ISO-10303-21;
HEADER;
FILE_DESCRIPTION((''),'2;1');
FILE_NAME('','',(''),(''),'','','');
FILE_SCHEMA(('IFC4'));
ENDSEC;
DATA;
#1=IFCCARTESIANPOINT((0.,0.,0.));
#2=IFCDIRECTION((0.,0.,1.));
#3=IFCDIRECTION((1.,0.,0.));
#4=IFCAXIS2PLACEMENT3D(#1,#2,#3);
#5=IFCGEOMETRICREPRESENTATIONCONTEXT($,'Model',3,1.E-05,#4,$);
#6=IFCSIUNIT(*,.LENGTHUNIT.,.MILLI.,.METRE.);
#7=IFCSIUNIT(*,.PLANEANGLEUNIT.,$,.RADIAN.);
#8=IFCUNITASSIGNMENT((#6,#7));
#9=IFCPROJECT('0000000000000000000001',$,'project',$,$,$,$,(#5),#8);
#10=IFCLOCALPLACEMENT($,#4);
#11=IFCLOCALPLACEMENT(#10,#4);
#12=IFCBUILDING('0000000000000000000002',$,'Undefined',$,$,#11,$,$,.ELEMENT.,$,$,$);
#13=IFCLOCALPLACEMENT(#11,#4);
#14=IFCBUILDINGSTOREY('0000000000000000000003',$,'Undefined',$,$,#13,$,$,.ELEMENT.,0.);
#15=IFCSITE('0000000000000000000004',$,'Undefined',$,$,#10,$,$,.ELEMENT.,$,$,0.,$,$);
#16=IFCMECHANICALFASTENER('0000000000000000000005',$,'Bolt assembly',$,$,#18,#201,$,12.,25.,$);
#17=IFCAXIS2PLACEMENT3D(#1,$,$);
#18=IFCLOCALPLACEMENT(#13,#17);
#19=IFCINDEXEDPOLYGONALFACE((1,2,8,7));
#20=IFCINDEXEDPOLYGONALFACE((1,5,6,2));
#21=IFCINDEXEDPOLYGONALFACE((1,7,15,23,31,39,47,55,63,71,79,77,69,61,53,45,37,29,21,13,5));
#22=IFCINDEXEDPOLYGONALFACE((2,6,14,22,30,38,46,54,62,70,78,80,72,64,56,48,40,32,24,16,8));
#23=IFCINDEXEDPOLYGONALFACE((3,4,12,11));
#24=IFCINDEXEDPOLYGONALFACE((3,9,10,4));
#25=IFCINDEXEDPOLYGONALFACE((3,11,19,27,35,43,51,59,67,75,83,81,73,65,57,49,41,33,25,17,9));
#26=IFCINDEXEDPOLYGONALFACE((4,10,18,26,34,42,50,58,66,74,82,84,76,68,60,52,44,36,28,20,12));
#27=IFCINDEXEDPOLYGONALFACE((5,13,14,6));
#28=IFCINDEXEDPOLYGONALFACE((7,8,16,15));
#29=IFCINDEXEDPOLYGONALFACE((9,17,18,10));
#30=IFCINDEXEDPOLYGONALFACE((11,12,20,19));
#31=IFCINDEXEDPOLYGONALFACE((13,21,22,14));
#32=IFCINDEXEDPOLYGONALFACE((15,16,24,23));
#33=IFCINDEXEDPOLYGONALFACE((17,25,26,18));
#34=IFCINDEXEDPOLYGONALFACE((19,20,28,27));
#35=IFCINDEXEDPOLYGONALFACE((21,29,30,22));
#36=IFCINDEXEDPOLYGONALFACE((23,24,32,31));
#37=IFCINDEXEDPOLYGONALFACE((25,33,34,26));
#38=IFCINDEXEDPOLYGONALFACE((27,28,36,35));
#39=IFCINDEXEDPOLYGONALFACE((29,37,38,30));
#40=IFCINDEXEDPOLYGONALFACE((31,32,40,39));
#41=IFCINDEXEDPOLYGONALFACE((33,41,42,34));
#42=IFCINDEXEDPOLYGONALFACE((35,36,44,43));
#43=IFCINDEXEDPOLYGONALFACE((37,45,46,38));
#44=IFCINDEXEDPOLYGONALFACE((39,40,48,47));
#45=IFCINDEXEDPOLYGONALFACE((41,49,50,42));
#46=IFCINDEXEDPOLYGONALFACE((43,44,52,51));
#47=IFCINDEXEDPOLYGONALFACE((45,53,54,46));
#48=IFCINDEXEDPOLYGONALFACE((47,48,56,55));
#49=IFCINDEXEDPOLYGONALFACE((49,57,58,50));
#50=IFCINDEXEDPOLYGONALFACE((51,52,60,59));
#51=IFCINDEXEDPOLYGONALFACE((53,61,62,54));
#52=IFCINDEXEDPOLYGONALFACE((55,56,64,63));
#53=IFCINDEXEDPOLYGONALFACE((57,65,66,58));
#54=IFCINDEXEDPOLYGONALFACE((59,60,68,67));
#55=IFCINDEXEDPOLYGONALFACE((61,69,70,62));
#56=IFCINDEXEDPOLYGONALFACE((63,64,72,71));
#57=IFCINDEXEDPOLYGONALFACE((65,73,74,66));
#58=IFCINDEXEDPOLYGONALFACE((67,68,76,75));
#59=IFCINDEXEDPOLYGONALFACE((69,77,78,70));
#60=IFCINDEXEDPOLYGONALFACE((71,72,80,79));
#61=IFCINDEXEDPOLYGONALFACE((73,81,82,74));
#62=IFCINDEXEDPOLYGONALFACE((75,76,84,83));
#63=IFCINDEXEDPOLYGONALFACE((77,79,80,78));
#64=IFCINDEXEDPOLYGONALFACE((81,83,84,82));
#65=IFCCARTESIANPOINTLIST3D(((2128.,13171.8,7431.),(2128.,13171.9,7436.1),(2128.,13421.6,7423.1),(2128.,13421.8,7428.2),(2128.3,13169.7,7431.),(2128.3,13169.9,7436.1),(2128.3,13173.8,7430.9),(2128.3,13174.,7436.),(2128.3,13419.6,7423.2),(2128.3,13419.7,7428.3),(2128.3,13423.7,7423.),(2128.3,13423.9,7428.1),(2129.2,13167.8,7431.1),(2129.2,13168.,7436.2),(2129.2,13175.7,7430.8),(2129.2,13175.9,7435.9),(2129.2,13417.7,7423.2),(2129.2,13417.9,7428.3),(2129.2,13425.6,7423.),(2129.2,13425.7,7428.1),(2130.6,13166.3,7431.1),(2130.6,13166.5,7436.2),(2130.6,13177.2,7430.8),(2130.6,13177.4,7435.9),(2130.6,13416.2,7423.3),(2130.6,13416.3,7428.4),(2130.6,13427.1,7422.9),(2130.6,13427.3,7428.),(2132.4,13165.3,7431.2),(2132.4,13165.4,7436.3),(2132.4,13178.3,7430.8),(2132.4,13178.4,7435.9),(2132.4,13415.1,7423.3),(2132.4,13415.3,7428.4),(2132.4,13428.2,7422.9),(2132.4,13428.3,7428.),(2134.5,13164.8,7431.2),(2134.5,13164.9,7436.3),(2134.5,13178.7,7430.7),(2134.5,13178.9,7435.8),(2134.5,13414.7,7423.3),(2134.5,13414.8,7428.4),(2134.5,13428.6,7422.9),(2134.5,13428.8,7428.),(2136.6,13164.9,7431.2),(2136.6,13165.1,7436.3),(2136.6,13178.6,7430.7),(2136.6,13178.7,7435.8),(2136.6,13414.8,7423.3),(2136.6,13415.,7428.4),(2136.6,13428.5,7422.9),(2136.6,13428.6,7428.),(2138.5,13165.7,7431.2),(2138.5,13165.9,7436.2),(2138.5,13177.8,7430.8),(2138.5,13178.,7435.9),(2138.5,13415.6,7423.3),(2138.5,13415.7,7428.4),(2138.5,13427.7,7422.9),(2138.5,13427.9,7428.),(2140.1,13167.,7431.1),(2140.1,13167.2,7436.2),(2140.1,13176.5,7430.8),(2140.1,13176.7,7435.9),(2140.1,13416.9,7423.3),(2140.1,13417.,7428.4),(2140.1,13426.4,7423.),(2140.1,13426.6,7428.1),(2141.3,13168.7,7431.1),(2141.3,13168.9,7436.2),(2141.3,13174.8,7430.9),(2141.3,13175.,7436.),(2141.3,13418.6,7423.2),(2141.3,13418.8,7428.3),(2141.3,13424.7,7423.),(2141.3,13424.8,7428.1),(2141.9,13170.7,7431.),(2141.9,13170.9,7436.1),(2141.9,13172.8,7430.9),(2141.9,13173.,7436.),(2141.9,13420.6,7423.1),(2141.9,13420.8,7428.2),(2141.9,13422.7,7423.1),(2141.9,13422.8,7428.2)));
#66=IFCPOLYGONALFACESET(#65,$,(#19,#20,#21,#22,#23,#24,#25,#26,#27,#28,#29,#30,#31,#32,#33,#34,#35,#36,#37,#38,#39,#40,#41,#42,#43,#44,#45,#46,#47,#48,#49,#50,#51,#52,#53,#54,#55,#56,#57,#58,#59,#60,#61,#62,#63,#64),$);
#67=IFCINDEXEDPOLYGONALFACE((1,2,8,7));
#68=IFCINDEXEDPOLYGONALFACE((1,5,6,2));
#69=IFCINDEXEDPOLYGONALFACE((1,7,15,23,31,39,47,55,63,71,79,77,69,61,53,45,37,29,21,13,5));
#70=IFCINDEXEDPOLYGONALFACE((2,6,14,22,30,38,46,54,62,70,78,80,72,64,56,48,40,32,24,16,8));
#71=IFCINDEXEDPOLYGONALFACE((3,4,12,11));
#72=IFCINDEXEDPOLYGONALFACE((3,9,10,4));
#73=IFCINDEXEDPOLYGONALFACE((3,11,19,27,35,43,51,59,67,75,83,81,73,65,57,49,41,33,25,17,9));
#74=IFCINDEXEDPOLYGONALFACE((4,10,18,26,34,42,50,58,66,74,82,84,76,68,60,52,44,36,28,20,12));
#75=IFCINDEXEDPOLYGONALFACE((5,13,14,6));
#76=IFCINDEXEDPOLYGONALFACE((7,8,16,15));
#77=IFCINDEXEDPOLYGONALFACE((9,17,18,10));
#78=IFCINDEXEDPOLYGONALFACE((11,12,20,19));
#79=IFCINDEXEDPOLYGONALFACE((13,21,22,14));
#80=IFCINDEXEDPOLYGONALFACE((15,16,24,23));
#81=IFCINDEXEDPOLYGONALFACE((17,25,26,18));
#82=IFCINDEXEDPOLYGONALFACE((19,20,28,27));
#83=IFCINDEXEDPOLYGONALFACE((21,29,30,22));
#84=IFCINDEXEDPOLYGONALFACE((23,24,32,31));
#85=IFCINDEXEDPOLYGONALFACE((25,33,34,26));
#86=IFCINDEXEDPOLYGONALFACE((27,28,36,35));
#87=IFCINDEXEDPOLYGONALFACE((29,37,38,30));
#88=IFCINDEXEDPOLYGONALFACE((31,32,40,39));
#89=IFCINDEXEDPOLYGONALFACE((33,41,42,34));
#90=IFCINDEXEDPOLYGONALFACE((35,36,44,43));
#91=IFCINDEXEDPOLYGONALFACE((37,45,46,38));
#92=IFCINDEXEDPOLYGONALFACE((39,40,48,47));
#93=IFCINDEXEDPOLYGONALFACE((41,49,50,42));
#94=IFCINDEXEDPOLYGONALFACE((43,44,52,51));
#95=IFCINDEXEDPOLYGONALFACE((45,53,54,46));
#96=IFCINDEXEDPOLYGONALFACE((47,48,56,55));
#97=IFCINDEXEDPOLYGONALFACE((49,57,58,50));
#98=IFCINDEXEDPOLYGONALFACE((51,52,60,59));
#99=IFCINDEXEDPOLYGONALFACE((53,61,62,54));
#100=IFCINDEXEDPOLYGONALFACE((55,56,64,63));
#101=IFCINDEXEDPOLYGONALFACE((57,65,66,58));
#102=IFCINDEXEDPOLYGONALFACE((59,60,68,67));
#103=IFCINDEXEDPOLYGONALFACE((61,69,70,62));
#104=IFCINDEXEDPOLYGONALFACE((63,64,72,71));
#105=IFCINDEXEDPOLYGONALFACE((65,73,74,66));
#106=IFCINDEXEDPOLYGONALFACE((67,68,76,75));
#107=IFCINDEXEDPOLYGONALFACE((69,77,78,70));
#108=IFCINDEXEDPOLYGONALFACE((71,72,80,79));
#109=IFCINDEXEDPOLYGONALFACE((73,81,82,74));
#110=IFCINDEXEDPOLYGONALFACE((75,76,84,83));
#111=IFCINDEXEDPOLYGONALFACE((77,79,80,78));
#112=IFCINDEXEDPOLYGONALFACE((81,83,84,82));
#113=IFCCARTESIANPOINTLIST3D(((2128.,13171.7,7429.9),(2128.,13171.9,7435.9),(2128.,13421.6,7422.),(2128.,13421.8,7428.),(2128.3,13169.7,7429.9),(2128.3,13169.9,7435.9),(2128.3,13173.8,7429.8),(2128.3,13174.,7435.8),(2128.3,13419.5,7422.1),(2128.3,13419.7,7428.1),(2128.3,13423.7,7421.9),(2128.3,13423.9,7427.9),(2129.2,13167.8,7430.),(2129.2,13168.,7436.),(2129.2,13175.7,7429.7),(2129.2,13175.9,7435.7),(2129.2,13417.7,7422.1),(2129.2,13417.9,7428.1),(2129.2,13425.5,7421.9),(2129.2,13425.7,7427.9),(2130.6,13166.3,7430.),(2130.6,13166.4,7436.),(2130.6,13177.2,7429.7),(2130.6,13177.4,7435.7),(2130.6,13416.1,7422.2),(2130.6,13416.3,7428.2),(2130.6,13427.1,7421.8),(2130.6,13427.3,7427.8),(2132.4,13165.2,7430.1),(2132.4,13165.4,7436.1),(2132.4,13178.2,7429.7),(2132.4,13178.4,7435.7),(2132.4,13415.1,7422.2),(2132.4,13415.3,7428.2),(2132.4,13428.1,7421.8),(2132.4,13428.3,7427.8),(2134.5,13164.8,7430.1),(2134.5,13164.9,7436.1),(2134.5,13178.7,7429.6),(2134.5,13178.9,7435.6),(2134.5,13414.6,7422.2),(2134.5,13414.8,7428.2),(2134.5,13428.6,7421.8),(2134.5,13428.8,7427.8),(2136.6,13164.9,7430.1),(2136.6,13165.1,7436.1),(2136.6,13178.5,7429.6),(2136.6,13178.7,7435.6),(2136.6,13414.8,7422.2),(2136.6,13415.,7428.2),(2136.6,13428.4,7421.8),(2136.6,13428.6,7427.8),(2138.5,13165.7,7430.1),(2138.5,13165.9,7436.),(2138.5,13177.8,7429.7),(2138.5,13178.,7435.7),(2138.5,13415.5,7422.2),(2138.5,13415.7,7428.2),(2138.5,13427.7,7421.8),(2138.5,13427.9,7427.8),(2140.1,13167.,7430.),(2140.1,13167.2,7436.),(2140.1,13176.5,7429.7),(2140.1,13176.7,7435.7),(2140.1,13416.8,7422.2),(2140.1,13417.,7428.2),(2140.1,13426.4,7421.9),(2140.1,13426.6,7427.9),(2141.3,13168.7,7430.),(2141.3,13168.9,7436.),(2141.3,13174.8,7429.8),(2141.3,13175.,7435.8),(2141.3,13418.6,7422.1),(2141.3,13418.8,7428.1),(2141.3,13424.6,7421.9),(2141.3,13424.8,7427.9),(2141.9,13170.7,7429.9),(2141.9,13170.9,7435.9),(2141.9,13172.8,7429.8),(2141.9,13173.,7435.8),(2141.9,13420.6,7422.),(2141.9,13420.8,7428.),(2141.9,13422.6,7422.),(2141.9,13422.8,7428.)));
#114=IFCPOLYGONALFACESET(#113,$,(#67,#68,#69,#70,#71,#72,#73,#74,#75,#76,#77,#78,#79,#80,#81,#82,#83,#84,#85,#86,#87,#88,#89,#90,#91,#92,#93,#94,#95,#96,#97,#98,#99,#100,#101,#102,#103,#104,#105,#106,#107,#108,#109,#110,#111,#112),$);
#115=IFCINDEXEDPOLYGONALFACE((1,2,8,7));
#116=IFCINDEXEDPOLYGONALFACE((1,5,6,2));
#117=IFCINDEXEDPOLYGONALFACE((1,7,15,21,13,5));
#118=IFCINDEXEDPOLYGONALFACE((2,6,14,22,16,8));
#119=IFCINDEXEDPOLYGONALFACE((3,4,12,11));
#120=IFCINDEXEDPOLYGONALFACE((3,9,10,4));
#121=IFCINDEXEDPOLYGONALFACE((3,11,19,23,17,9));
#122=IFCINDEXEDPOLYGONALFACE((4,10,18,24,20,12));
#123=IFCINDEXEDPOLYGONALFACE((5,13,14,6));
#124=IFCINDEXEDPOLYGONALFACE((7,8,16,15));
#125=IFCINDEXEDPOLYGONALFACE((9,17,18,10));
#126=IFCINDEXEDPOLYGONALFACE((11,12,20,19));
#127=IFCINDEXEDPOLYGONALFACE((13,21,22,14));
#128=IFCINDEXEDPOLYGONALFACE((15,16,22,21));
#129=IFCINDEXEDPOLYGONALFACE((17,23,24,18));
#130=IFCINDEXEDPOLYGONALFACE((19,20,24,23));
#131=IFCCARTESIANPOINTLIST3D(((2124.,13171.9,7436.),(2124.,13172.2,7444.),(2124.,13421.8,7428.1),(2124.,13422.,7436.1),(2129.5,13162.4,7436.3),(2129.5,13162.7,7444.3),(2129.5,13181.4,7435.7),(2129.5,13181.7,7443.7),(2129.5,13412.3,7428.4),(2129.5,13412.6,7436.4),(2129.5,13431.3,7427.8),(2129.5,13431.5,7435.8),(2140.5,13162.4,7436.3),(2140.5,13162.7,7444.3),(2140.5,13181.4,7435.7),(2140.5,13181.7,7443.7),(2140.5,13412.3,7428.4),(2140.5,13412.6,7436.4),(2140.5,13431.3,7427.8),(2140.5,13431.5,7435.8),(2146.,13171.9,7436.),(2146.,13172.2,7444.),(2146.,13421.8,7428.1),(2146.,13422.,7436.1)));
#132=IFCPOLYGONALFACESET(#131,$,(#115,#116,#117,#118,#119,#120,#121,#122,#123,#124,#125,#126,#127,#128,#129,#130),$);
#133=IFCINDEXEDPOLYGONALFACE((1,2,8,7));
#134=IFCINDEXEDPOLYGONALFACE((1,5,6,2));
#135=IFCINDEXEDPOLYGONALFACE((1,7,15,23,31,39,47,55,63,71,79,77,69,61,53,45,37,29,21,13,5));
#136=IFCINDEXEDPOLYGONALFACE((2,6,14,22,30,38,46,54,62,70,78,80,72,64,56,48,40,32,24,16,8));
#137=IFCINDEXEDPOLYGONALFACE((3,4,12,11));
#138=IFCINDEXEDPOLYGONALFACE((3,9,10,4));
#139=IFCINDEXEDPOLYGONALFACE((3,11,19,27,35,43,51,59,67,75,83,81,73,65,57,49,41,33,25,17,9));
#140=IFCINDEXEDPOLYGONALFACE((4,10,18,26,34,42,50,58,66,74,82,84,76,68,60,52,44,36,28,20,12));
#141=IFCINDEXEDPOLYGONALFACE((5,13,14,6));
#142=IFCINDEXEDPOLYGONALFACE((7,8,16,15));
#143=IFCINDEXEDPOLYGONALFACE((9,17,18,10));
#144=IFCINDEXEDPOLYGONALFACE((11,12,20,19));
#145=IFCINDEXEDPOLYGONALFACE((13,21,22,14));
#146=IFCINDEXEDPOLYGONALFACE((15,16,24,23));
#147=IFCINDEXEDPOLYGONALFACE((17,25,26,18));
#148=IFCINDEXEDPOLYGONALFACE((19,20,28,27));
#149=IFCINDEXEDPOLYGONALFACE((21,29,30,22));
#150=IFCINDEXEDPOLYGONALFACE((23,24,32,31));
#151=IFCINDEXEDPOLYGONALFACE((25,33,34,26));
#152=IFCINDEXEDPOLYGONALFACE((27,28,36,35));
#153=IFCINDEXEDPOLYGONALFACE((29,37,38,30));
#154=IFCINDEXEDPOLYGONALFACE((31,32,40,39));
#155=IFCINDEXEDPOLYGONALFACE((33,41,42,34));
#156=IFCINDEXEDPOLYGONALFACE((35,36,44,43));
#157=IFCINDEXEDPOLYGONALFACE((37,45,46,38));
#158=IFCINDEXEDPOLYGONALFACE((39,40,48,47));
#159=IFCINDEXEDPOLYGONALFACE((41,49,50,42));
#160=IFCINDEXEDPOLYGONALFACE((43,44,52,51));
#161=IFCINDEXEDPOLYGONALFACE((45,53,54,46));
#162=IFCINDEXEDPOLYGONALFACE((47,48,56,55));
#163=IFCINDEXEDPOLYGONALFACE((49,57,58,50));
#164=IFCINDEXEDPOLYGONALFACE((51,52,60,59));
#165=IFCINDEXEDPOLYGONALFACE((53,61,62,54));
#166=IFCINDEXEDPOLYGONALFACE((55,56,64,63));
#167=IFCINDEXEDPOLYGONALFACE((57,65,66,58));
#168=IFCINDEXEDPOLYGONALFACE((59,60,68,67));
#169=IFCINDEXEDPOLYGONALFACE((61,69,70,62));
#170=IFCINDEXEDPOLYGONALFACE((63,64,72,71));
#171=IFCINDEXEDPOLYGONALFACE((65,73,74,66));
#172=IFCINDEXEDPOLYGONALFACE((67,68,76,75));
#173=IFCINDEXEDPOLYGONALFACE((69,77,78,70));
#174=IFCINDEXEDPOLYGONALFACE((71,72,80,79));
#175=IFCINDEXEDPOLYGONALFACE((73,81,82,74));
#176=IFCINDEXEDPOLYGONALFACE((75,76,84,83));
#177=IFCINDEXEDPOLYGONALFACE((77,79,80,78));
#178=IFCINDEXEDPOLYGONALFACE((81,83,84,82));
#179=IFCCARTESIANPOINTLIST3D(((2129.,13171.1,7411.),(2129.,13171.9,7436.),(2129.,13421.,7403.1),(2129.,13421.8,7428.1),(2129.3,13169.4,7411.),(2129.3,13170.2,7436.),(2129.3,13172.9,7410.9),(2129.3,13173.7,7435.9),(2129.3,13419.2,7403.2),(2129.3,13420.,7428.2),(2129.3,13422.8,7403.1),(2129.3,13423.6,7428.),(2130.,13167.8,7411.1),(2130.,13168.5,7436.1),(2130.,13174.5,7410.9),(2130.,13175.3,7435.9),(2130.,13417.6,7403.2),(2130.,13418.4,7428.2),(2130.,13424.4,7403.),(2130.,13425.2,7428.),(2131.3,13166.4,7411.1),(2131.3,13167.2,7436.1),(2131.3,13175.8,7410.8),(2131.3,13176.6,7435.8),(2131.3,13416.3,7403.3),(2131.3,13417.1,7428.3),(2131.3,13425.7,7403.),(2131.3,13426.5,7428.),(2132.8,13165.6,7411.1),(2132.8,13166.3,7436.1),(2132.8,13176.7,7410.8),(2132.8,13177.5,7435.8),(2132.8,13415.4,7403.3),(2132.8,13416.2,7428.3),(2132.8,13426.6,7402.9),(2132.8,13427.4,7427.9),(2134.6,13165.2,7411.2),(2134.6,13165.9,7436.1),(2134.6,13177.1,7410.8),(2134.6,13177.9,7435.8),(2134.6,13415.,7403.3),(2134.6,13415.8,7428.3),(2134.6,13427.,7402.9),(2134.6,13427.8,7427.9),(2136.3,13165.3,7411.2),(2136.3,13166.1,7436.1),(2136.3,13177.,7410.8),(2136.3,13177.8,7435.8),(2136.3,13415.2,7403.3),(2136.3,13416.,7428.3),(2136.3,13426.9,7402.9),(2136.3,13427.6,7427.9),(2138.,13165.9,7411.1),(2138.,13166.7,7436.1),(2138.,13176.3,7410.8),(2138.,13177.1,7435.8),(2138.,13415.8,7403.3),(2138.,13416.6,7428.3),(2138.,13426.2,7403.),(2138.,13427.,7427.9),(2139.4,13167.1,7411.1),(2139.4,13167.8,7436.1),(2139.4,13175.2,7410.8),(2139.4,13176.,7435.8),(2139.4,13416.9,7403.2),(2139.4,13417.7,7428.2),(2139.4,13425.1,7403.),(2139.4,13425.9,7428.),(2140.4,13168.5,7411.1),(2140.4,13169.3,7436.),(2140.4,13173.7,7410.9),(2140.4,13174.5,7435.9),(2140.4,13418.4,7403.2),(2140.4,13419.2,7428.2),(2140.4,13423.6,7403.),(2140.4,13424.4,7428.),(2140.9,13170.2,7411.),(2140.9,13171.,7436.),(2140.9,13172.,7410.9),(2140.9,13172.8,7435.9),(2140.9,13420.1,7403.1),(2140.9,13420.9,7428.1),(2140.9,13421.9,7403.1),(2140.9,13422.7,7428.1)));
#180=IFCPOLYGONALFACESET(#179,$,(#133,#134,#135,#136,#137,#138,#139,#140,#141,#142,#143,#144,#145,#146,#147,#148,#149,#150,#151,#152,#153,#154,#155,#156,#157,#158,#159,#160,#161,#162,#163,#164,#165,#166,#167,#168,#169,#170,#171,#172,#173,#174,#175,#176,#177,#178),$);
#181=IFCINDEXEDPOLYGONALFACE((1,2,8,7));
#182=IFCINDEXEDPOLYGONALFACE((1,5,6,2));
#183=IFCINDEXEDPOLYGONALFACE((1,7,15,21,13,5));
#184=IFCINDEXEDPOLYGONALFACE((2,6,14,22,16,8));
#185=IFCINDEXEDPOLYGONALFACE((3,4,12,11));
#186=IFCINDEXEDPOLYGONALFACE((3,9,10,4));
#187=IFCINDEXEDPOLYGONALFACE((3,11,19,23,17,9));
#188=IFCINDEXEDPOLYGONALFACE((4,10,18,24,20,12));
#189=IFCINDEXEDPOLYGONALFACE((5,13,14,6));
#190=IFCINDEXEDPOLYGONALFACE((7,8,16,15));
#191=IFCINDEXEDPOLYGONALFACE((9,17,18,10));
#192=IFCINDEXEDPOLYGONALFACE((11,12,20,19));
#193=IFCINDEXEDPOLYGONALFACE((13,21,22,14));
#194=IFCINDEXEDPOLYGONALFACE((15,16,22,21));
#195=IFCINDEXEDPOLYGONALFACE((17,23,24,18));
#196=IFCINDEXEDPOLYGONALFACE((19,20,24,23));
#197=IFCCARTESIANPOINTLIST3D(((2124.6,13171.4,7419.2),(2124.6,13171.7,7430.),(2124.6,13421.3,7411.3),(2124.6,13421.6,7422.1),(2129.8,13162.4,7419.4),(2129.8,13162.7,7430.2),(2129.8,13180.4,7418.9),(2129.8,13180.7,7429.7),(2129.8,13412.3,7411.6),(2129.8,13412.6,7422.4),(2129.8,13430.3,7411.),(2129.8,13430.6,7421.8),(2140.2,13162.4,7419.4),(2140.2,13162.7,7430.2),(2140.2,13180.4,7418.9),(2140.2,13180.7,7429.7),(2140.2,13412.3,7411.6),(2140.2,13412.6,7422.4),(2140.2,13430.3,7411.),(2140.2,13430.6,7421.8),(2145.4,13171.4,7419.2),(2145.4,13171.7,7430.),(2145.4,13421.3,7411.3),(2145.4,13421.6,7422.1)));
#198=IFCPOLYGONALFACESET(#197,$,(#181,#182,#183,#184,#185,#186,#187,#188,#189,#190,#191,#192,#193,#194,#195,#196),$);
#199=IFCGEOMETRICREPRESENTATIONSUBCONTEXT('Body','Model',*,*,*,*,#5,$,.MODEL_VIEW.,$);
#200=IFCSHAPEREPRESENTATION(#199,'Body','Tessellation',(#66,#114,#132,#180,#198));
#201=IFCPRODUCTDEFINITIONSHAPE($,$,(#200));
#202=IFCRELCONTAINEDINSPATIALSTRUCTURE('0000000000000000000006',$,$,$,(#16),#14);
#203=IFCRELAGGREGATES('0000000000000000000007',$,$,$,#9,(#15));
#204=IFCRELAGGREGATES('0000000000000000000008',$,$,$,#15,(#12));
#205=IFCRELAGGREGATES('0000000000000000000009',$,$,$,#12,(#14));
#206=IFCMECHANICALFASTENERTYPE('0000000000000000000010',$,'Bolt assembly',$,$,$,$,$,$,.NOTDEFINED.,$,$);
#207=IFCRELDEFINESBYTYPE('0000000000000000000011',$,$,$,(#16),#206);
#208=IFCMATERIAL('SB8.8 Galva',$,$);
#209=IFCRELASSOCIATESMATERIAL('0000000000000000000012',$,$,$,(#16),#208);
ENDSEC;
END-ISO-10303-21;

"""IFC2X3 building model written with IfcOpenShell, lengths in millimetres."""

from ifc_helpers import new_model, si_unit, frame, origin_with_axes, origin_2d_with_axis, place, context, subcontext, project, spatial, polyline, circle, outline, extrude, source, transform, mapped, material, type_object, element, save


model = new_model("IFC2X3")

# Units and contexts
model_context = context("Model", 3, precision=1e-05, world=origin_with_axes())
body_context = subcontext(model_context, "Body", "Model", "MODEL_VIEW")
ifc_project = project(units=[si_unit("LENGTHUNIT", "METRE", prefix="MILLI"), si_unit("PLANEANGLEUNIT", "RADIAN")], contexts=[model_context])

# Site, building, storey
site_placement = place(None, origin_with_axes())
site = spatial("IfcSite", under=ifc_project, at=site_placement, Name="Undefined", CompositionType="ELEMENT", RefElevation=0.0)
building_placement = place(site_placement, origin_with_axes())
building = spatial("IfcBuilding", under=site, at=building_placement, Name="Undefined", CompositionType="ELEMENT")
storey_placement = place(building_placement, origin_with_axes())
storey = spatial("IfcBuildingStorey", under=building, at=storey_placement, Name="Undefined", CompositionType="ELEMENT", Elevation=0.0)

# Mechanical fastener
mechanical_fastener_type = type_object("IfcMechanicalFastenerType", Name="Bolt assembly")
ifc_material_1 = material(Name="SB8.8 Galva")
shared_shape_1 = source(origin_with_axes(), body_context, "Body", "SweptSolid", [
    extrude(circle(Radius=7.0, at=origin_2d_with_axis()), frame((0.0, -0.1, 0.0), z_axis=(0.0, 1.0, 0.0), x_axis=(1.0, 0.0, 0.0)), (0.0, 0.0, 1.0), 5.1),
    extrude(circle(Radius=7.0, at=origin_2d_with_axis()), frame((0.0, 0.1, 0.0), z_axis=(0.0, 1.0, 0.0), x_axis=(1.0, 0.0, 0.0)), (0.0, 0.0, 1.0), 6.0),
    extrude(outline(polyline([(11.0, 0.0), (5.5, 9.5), (-5.5, 9.5), (-11.0, 0.0), (-5.5, -9.5), (5.5, -9.5), (11.0, 0.0)])), frame((0.0, -8.0, 0.0), z_axis=(0.0, 1.0, 0.0), x_axis=(1.0, 0.0, 0.0)), (0.0, 0.0, 1.0), 8.0),
    extrude(circle(Radius=6.0, at=origin_2d_with_axis()), frame((0.0, 0.0, 0.0), z_axis=(0.0, 1.0, 0.0), x_axis=(1.0, 0.0, 0.0)), (0.0, 0.0, 1.0), 25.0),
    extrude(outline(polyline([(10.4, 0.0), (5.2, 9.0), (-5.2, 9.0), (-10.4, 0.0), (-5.2, -9.0), (5.2, -9.0), (10.4, 0.0)])), frame((0.0, 6.0, 0.0), z_axis=(0.0, 1.0, 0.0), x_axis=(1.0, 0.0, 0.0)), (0.0, 0.0, 1.0), 10.8),
])
mechanical_fastener_1_placement = place(storey_placement, frame((2135.0, 13296.9, 7432.0), z_axis=(0.0, -0.999507, 0.031411), x_axis=(-1.0, 0.0, 0.0)))
element("IfcMechanicalFastener", 1, at=mechanical_fastener_1_placement, inside=storey, type_object=mechanical_fastener_type, material=ifc_material_1, Name="Bolt assembly", NominalDiameter=12.0, NominalLength=25.0, context=body_context, shape_type="MappedRepresentation", body=[
    mapped(shared_shape_1, transform((0.0, 0.0, -125.0))),
    mapped(shared_shape_1, transform((0.0, 0.0, 125.0))),
])

save(model, "model.ifc")
